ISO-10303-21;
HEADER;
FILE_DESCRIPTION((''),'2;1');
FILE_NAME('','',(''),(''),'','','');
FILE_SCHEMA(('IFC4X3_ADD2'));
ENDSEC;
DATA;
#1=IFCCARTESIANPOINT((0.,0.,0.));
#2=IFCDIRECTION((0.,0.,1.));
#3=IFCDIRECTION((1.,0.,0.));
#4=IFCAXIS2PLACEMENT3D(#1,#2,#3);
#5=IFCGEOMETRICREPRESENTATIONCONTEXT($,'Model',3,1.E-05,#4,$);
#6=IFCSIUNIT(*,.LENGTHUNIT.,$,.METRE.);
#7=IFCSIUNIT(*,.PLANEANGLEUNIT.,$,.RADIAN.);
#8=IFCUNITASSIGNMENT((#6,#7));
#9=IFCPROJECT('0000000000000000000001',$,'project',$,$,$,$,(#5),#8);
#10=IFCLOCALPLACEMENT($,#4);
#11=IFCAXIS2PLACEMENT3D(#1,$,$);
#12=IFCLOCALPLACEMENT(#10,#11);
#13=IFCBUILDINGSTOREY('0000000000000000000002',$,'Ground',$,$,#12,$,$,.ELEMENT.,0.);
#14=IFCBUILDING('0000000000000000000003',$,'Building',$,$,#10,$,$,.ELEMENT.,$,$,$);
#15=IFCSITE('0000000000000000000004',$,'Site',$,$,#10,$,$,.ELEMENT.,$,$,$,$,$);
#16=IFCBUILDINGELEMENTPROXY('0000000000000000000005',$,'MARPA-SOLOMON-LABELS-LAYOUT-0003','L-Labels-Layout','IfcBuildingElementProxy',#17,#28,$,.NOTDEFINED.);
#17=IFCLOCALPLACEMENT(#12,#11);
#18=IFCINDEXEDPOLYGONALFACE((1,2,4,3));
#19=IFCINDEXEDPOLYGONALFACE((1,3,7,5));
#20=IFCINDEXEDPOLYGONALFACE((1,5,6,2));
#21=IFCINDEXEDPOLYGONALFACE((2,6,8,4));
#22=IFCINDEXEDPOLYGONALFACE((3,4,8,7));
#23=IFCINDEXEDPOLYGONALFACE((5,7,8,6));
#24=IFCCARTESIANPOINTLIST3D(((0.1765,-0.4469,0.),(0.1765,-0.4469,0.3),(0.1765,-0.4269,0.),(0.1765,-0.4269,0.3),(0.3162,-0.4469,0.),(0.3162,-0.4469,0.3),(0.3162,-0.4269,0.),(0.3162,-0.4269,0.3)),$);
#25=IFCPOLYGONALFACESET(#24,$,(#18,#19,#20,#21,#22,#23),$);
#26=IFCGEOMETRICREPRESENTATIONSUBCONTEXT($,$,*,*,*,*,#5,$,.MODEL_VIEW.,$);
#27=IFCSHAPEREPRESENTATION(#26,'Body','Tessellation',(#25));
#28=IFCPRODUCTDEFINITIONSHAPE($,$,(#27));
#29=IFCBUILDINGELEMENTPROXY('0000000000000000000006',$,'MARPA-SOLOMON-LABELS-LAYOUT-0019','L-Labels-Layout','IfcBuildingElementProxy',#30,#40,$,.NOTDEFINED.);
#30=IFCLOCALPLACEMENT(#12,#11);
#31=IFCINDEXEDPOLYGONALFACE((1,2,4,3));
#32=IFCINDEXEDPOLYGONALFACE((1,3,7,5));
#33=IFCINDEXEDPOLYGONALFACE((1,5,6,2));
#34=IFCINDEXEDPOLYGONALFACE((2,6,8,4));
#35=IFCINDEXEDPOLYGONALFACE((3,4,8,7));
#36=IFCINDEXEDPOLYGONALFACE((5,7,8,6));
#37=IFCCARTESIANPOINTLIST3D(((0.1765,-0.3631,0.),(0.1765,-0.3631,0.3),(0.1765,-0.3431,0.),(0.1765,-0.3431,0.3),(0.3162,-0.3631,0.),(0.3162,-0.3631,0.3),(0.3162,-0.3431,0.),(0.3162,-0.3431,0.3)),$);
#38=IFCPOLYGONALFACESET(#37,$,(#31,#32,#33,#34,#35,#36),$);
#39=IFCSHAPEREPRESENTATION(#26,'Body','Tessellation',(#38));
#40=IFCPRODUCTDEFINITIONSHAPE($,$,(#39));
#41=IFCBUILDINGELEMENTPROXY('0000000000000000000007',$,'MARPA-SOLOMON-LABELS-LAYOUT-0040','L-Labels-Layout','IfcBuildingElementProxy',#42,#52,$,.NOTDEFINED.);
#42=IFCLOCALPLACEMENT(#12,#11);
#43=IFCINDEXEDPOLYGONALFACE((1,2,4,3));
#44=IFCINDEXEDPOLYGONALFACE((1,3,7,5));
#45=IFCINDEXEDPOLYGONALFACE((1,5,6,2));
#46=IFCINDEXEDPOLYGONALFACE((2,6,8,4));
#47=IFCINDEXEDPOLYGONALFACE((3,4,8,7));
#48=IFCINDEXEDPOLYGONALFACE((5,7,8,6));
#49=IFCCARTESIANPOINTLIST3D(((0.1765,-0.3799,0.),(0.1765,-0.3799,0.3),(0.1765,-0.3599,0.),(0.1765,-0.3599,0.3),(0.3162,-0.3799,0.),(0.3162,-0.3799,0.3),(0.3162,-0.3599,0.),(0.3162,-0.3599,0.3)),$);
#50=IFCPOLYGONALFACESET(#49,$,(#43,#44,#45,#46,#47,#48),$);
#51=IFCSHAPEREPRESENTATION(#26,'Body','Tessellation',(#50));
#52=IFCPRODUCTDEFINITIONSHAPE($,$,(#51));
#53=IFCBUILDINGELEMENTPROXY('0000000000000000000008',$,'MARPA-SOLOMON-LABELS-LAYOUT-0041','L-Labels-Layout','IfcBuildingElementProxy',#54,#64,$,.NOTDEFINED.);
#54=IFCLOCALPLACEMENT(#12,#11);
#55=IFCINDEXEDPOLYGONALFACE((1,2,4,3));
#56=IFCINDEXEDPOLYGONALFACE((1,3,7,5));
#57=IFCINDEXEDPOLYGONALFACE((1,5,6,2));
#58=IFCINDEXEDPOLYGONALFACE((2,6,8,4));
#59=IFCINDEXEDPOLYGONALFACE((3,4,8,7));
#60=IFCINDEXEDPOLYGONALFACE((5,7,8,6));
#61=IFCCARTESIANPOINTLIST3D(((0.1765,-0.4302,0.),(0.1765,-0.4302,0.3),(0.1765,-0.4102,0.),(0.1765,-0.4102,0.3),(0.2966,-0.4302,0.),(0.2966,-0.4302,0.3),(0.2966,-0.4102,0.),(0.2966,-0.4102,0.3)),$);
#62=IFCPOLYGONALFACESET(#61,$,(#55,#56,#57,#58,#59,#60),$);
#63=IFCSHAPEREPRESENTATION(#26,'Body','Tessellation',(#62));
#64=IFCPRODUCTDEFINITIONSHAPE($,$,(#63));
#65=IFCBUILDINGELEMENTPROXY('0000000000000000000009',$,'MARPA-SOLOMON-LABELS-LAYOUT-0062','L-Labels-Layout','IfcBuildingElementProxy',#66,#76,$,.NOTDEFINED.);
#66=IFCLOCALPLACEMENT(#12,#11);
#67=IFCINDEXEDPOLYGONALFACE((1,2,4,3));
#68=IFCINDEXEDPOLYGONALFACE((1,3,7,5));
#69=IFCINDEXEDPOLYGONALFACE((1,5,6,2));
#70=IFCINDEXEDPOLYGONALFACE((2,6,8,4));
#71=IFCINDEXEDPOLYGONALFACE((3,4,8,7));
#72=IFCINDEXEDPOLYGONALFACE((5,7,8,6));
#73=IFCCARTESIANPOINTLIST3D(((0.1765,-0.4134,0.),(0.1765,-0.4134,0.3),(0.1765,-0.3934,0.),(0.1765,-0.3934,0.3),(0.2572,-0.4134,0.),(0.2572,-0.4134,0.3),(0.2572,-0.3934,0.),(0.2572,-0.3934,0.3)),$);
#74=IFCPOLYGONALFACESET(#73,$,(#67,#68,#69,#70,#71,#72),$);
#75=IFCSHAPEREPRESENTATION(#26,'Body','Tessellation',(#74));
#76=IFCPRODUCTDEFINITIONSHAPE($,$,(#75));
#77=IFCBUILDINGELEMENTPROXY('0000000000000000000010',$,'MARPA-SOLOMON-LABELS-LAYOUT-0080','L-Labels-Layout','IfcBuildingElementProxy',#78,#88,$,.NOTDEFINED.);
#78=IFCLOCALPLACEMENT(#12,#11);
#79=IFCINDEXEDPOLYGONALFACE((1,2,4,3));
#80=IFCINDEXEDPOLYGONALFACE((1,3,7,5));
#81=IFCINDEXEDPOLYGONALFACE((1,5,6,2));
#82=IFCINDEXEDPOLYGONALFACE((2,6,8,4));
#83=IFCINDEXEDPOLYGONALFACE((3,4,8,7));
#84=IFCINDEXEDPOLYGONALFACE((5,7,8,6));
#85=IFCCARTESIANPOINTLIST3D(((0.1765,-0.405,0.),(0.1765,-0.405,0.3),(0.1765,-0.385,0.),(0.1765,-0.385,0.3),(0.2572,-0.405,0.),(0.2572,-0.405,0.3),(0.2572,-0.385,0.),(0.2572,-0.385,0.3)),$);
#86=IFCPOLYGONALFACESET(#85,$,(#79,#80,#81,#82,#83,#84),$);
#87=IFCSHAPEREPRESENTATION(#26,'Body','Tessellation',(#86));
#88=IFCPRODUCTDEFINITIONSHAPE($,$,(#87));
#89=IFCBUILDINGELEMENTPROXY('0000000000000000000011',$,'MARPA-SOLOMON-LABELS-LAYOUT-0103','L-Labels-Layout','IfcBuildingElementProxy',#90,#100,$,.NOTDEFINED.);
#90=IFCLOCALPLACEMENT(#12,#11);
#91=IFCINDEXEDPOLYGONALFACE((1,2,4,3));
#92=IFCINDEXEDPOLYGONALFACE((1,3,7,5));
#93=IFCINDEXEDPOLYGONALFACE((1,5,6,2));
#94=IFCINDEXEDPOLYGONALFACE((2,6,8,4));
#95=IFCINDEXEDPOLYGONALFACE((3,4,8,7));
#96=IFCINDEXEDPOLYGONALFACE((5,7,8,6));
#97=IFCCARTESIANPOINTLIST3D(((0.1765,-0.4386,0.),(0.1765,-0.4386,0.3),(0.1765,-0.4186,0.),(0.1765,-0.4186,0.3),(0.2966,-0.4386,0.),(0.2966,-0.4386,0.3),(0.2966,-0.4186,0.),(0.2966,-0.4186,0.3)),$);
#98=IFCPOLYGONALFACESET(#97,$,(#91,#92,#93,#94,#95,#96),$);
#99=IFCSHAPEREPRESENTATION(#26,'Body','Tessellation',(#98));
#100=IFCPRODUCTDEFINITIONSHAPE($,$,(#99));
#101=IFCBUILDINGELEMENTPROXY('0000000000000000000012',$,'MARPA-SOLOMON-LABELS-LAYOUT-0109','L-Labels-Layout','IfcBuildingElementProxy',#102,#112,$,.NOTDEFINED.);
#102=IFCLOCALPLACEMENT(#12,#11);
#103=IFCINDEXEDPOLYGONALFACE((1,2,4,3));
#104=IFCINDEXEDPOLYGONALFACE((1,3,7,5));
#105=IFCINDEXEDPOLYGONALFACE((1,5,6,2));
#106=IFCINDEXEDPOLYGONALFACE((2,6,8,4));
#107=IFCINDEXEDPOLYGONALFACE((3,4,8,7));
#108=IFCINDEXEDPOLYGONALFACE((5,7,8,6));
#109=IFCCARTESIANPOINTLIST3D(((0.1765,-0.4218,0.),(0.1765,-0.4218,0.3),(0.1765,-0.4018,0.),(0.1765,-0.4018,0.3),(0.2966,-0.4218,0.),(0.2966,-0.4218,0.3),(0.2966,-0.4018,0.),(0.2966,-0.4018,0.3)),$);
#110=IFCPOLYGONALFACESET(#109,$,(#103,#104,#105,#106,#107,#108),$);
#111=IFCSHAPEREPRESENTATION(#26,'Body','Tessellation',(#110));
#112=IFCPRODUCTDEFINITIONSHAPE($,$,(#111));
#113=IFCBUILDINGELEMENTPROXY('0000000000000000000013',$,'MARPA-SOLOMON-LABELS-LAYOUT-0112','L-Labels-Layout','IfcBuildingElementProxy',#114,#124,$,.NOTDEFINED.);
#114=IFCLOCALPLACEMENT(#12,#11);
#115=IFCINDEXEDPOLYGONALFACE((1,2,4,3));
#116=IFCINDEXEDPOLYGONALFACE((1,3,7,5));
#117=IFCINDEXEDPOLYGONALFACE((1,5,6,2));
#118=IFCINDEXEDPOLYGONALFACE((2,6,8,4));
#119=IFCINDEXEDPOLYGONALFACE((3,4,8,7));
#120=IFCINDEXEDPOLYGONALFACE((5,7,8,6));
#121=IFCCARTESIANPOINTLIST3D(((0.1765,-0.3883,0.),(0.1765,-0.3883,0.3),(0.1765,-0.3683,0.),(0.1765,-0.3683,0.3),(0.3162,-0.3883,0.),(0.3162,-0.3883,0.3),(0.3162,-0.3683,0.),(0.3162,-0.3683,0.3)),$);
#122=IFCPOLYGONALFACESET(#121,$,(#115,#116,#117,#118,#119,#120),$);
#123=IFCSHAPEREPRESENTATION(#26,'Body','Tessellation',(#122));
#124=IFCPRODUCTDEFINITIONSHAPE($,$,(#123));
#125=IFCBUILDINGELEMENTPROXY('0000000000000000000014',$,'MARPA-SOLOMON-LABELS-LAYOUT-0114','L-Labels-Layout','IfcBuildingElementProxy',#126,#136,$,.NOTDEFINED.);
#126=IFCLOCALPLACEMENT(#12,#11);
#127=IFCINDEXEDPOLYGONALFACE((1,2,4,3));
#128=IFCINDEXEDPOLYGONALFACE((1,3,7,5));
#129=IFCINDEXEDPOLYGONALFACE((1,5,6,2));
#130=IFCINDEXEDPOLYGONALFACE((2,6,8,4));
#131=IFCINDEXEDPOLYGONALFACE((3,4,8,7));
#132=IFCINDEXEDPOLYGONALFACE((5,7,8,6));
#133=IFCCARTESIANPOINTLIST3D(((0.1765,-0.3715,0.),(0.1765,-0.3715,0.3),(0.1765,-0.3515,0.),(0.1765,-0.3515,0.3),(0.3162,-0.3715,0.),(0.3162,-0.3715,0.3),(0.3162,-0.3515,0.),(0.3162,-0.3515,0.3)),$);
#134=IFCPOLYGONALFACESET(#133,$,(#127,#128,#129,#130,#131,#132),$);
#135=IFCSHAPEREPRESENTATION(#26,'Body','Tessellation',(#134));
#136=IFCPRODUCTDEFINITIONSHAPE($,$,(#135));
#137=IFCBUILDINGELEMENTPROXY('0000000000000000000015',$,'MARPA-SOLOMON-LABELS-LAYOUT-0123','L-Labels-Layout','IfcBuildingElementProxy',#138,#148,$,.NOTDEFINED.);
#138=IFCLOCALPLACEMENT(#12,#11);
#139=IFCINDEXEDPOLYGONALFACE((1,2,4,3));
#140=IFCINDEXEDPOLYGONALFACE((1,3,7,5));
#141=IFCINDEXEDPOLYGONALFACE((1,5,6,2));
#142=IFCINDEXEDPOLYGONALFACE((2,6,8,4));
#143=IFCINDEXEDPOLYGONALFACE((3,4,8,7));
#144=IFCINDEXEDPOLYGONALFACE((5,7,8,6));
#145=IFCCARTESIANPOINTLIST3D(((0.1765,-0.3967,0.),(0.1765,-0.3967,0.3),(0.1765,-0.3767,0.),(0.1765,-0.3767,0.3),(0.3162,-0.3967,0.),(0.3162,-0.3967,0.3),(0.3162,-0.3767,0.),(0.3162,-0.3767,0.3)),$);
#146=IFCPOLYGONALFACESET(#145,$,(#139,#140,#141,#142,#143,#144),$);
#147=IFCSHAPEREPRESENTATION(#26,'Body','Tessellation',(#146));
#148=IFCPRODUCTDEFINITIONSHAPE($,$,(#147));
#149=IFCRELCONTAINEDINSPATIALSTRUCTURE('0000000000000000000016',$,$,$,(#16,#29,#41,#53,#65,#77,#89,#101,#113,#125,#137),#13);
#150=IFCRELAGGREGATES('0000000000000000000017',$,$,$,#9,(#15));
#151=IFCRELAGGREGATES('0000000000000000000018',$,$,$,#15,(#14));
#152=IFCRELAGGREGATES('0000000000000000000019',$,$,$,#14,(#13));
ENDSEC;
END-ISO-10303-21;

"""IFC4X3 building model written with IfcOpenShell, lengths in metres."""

from ifc_helpers import new_model, si_unit, frame, frame_2d, origin, origin_with_axes, place, context, subcontext, project, spatial, rectangle, extrude, element, save


model = new_model("IFC4X3")

# Units and contexts
model_context = context("Model", 3, precision=1e-05, world=origin_with_axes())
sub_context = subcontext(model_context, None, None, "MODEL_VIEW")
ifc_project = project(units=[si_unit("LENGTHUNIT", "METRE"), si_unit("PLANEANGLEUNIT", "RADIAN")], contexts=[model_context])

# Site, building, storey
placement = place(None, origin_with_axes())
site = spatial("IfcSite", under=ifc_project, at=placement, Name="Site", CompositionType="ELEMENT")
building = spatial("IfcBuilding", under=site, at=placement, Name="Building", CompositionType="ELEMENT")
storey_placement = place(placement, origin())
storey = spatial("IfcBuildingStorey", under=building, at=storey_placement, Name="Ground", CompositionType="ELEMENT", Elevation=0.0)

# Building element proxies
for number, where, name in (
    (1, (0.1765, -0.4469, 0.0), "MARPA-SOLOMON-LABELS-LAYOUT-0003"),
    (2, (0.1765, -0.3631, 0.0), "MARPA-SOLOMON-LABELS-LAYOUT-0019"),
    (3, (0.1765, -0.3799, 0.0), "MARPA-SOLOMON-LABELS-LAYOUT-0040"),
):
    element("IfcBuildingElementProxy", number, at=place(placement, frame(where)), inside=storey, Name=name, Description="L-Labels-Layout", ObjectType="IfcBuildingElementProxy", PredefinedType="NOTDEFINED", context=sub_context, shape_type="SweptSolid", body=[
        extrude(rectangle(XDim=0.1397, YDim=0.02, at=frame_2d((0.0699, 0.01))), origin(), (0.0, 0.0, 1.0), 0.3),
    ])
proxy_1_placement = place(placement, frame((0.1765, -0.4302, 0.0)))
element("IfcBuildingElementProxy", 4, at=proxy_1_placement, inside=storey, Name="MARPA-SOLOMON-LABELS-LAYOUT-0041", Description="L-Labels-Layout", ObjectType="IfcBuildingElementProxy", PredefinedType="NOTDEFINED", context=sub_context, shape_type="SweptSolid", body=[
    extrude(rectangle(XDim=0.12, YDim=0.02, at=frame_2d((0.06, 0.01))), origin(), (0.0, 0.0, 1.0), 0.3),
])
proxy_2_placement = place(placement, frame((0.1765, -0.4134, 0.0)))
element("IfcBuildingElementProxy", 5, at=proxy_2_placement, inside=storey, Name="MARPA-SOLOMON-LABELS-LAYOUT-0062", Description="L-Labels-Layout", ObjectType="IfcBuildingElementProxy", PredefinedType="NOTDEFINED", context=sub_context, shape_type="SweptSolid", body=[
    extrude(rectangle(XDim=0.0807, YDim=0.02, at=frame_2d((0.0403, 0.01))), origin(), (0.0, 0.0, 1.0), 0.3),
])
proxy_3_placement = place(placement, frame((0.1765, -0.405, 0.0)))
element("IfcBuildingElementProxy", 6, at=proxy_3_placement, inside=storey, Name="MARPA-SOLOMON-LABELS-LAYOUT-0080", Description="L-Labels-Layout", ObjectType="IfcBuildingElementProxy", PredefinedType="NOTDEFINED", context=sub_context, shape_type="SweptSolid", body=[
    extrude(rectangle(XDim=0.0807, YDim=0.02, at=frame_2d((0.0403, 0.01))), origin(), (0.0, 0.0, 1.0), 0.3),
])
for number, where, name in (
    (7, (0.1765, -0.4386, 0.0), "MARPA-SOLOMON-LABELS-LAYOUT-0103"),
    (8, (0.1765, -0.4218, 0.0), "MARPA-SOLOMON-LABELS-LAYOUT-0109"),
):
    element("IfcBuildingElementProxy", number, at=place(placement, frame(where)), inside=storey, Name=name, Description="L-Labels-Layout", ObjectType="IfcBuildingElementProxy", PredefinedType="NOTDEFINED", context=sub_context, shape_type="SweptSolid", body=[
        extrude(rectangle(XDim=0.12, YDim=0.02, at=frame_2d((0.06, 0.01))), origin(), (0.0, 0.0, 1.0), 0.3),
    ])
for number, where, name in (
    (9, (0.1765, -0.3883, 0.0), "MARPA-SOLOMON-LABELS-LAYOUT-0112"),
    (10, (0.1765, -0.3715, 0.0), "MARPA-SOLOMON-LABELS-LAYOUT-0114"),
    (11, (0.1765, -0.3967, 0.0), "MARPA-SOLOMON-LABELS-LAYOUT-0123"),
):
    element("IfcBuildingElementProxy", number, at=place(placement, frame(where)), inside=storey, Name=name, Description="L-Labels-Layout", ObjectType="IfcBuildingElementProxy", PredefinedType="NOTDEFINED", context=sub_context, shape_type="SweptSolid", body=[
        extrude(rectangle(XDim=0.1397, YDim=0.02, at=frame_2d((0.0699, 0.01))), origin(), (0.0, 0.0, 1.0), 0.3),
    ])

save(model, "model.ifc")
